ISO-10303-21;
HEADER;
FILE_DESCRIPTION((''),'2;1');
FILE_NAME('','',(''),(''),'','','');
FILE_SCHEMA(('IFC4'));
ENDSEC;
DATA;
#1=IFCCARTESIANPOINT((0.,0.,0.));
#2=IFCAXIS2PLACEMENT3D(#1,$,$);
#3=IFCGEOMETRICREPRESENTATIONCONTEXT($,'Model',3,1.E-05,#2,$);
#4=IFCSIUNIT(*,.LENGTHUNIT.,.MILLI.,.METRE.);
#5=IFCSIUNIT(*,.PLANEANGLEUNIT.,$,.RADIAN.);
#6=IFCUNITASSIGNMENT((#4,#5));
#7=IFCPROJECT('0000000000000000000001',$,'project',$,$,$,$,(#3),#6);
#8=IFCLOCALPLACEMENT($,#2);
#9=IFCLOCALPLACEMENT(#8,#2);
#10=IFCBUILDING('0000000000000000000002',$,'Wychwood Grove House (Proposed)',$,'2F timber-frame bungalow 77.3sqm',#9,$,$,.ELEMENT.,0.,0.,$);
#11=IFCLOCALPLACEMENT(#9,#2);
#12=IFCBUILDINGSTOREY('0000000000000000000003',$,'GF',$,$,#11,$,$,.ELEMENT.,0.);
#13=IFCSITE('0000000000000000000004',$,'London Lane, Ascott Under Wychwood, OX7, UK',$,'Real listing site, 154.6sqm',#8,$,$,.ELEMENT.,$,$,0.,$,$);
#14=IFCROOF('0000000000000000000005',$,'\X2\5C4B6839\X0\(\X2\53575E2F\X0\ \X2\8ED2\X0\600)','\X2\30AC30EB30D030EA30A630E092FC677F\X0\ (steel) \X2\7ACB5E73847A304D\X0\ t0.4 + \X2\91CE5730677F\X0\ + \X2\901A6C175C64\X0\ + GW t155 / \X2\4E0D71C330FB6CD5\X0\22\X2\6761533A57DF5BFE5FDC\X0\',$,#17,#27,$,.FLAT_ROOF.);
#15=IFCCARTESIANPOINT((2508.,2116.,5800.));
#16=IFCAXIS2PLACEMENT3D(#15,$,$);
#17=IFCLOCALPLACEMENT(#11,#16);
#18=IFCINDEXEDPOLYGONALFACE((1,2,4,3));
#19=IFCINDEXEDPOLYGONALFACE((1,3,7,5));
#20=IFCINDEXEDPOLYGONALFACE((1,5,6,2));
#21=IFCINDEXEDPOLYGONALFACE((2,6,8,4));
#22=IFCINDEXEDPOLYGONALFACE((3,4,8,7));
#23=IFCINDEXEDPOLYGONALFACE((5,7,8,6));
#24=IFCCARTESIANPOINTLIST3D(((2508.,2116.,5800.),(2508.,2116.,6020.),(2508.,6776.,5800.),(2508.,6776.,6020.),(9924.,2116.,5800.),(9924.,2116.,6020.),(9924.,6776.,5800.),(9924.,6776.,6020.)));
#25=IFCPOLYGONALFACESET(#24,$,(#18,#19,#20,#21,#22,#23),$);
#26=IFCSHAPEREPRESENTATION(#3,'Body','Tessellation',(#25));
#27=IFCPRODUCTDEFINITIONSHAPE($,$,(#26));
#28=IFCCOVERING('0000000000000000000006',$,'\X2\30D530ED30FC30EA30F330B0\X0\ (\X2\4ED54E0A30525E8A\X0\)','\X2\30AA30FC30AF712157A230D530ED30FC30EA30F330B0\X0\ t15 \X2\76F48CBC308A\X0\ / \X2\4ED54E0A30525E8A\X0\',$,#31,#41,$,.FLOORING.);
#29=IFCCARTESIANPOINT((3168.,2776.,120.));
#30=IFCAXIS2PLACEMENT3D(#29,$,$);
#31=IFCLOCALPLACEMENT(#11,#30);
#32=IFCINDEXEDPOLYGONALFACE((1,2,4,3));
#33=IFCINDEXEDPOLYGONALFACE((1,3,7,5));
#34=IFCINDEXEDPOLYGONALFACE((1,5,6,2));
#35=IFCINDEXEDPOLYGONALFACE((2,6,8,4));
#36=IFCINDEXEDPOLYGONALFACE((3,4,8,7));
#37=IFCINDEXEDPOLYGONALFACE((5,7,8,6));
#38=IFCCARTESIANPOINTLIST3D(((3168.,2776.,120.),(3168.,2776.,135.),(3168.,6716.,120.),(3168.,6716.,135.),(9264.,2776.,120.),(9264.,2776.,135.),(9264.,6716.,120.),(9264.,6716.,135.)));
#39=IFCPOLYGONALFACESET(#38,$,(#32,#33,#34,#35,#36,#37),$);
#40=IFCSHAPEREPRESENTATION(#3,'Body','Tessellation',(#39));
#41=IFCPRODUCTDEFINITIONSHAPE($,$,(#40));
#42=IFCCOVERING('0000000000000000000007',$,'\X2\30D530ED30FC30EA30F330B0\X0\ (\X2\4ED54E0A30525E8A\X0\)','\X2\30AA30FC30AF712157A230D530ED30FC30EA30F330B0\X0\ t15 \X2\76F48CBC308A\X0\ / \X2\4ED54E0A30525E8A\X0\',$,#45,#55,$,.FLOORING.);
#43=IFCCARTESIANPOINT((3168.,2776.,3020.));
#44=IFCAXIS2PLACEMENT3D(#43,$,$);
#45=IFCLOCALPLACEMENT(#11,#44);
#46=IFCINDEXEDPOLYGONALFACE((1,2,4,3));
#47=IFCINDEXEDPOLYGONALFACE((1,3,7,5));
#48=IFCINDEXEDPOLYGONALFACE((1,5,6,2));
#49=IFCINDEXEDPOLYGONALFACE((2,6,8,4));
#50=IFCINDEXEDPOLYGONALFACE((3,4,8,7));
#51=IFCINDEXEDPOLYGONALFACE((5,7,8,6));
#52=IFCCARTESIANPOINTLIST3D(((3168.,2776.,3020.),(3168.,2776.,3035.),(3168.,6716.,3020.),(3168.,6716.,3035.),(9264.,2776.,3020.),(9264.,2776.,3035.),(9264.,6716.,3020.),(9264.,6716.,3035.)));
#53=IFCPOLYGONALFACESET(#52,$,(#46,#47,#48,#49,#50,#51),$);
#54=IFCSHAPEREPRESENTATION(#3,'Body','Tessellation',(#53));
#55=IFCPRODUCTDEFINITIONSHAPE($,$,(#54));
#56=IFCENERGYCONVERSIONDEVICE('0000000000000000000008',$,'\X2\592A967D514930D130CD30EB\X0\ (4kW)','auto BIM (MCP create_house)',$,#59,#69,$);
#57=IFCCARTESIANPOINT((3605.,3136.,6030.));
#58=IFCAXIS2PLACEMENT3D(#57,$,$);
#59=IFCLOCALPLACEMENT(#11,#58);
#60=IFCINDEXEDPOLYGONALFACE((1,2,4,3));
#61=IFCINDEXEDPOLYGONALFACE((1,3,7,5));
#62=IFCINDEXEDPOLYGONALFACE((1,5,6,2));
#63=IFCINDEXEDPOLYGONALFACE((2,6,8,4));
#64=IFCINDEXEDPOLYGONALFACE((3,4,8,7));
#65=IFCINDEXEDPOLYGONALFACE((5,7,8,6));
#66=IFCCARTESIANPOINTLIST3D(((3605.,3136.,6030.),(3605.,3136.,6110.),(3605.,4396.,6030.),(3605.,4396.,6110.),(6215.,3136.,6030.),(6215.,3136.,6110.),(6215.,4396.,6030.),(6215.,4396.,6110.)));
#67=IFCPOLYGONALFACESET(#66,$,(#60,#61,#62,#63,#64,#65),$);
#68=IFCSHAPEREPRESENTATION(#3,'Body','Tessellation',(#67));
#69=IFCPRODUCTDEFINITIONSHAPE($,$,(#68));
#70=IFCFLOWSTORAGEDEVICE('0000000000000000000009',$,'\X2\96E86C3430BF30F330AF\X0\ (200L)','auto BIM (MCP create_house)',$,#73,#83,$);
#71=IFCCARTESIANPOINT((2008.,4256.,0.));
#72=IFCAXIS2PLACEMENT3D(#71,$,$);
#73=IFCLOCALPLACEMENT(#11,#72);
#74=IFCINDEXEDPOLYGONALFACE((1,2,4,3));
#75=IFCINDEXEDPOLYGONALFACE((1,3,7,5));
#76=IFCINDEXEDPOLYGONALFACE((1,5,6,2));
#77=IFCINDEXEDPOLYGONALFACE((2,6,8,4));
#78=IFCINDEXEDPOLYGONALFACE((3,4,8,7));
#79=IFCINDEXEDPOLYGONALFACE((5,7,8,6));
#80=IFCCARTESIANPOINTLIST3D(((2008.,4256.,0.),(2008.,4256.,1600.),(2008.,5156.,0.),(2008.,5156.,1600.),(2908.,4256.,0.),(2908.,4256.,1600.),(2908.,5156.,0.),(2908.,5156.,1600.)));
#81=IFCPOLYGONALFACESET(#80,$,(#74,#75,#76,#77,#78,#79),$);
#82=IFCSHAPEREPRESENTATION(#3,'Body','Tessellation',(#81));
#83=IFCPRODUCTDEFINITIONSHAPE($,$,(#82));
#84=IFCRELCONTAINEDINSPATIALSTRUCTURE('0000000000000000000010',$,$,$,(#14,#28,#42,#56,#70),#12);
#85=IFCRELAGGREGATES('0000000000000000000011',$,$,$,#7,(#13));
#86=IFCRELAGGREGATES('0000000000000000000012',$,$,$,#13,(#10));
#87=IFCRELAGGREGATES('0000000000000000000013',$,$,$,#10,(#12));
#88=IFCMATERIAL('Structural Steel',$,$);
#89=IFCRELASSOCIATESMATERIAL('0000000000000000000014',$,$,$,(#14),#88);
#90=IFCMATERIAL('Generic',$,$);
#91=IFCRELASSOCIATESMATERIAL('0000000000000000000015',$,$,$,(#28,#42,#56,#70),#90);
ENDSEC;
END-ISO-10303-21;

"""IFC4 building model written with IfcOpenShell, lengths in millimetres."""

from ifc_helpers import new_model, si_unit, frame, frame_2d, origin, place, context, project, spatial, rectangle, extrude, material, element, save


model = new_model("IFC4")

# Units and contexts
model_context = context("Model", 3, precision=1e-05, world=origin())
ifc_project = project(units=[si_unit("LENGTHUNIT", "METRE", prefix="MILLI"), si_unit("PLANEANGLEUNIT", "RADIAN")], contexts=[model_context])

# Site, building, storey
site_placement = place(None, origin())
site = spatial("IfcSite", under=ifc_project, at=site_placement, Name="London Lane, Ascott Under Wychwood, OX7, UK", ObjectType="Real listing site, 154.6sqm", CompositionType="ELEMENT", RefElevation=0.0)
building_placement = place(site_placement, origin())
building = spatial("IfcBuilding", under=site, at=building_placement, Name="Wychwood Grove House (Proposed)", ObjectType="2F timber-frame bungalow 77.3sqm", CompositionType="ELEMENT", ElevationOfRefHeight=0.0, ElevationOfTerrain=0.0)
storey_placement = place(building_placement, origin())
storey = spatial("IfcBuildingStorey", under=building, at=storey_placement, Name="GF", CompositionType="ELEMENT", Elevation=0.0)

# Roof
ifc_material_1 = material(Name="Structural Steel")
for number, where, name in (
    (1, (2508.0, 2116.0, 5800.0), "屋根(南帯 軒600)"),
):
    element("IfcRoof", number, at=place(storey_placement, frame(where)), inside=storey, material=ifc_material_1, Name=name, Description="ガルバリウム鋼板 (steel) 立平葺き t0.4 + 野地板 + 通気層 + GW t155 / 不燃・法22条区域対応", PredefinedType="FLAT_ROOF", context=model_context, shape_type="SweptSolid", body=[
        extrude(rectangle(XDim=7416.0, YDim=4660.0, at=frame_2d((3708.0, 2330.0))), frame((2508.0, 2116.0, 5800.0)), (0.0, 0.0, 1.0), 220.0),
    ])

# Coverings
ifc_material_2 = material(Name="Generic")
covering_1_placement = place(storey_placement, frame((3168.0, 2776.0, 120.0)))
element("IfcCovering", 2, at=covering_1_placement, inside=storey, material=ifc_material_2, Name="フローリング (仕上げ床)", Description="オーク無垢フローリング t15 直貼り / 仕上げ床", PredefinedType="FLOORING", context=model_context, shape_type="SweptSolid", body=[
    extrude(rectangle(XDim=6096.0, YDim=3940.0, at=frame_2d((3048.0, 1970.0))), frame((3168.0, 2776.0, 120.0)), (0.0, 0.0, 1.0), 15.0),
])
covering_2_placement = place(storey_placement, frame((3168.0, 2776.0, 3020.0)))
element("IfcCovering", 3, at=covering_2_placement, inside=storey, material=ifc_material_2, Name="フローリング (仕上げ床)", Description="オーク無垢フローリング t15 直貼り / 仕上げ床", PredefinedType="FLOORING", context=model_context, shape_type="SweptSolid", body=[
    extrude(rectangle(XDim=6096.0, YDim=3940.0, at=frame_2d((3048.0, 1970.0))), frame((3168.0, 2776.0, 3020.0)), (0.0, 0.0, 1.0), 15.0),
])

# Energy conversion device
energy_conversion_device_placement = place(storey_placement, frame((3605.0, 3136.0, 6030.0)))
element("IfcEnergyConversionDevice", 4, at=energy_conversion_device_placement, inside=storey, material=ifc_material_2, Name="太陽光パネル (4kW)", Description="auto BIM (MCP create_house)", context=model_context, shape_type="SweptSolid", body=[
    extrude(rectangle(XDim=2610.0, YDim=1260.0, at=frame_2d((1305.0, 630.0))), frame((3605.0, 3136.0, 6030.0)), (0.0, 0.0, 1.0), 80.0),
])

# Flow storage device
flow_storage_device_placement = place(storey_placement, frame((2008.0, 4256.0, 0.0)))
element("IfcFlowStorageDevice", 5, at=flow_storage_device_placement, inside=storey, material=ifc_material_2, Name="雨水タンク (200L)", Description="auto BIM (MCP create_house)", context=model_context, shape_type="SweptSolid", body=[
    extrude(rectangle(XDim=900.0, YDim=900.0, at=frame_2d((450.0, 450.0))), frame((2008.0, 4256.0, 0.0)), (0.0, 0.0, 1.0), 1600.0),
])

save(model, "model.ifc")
